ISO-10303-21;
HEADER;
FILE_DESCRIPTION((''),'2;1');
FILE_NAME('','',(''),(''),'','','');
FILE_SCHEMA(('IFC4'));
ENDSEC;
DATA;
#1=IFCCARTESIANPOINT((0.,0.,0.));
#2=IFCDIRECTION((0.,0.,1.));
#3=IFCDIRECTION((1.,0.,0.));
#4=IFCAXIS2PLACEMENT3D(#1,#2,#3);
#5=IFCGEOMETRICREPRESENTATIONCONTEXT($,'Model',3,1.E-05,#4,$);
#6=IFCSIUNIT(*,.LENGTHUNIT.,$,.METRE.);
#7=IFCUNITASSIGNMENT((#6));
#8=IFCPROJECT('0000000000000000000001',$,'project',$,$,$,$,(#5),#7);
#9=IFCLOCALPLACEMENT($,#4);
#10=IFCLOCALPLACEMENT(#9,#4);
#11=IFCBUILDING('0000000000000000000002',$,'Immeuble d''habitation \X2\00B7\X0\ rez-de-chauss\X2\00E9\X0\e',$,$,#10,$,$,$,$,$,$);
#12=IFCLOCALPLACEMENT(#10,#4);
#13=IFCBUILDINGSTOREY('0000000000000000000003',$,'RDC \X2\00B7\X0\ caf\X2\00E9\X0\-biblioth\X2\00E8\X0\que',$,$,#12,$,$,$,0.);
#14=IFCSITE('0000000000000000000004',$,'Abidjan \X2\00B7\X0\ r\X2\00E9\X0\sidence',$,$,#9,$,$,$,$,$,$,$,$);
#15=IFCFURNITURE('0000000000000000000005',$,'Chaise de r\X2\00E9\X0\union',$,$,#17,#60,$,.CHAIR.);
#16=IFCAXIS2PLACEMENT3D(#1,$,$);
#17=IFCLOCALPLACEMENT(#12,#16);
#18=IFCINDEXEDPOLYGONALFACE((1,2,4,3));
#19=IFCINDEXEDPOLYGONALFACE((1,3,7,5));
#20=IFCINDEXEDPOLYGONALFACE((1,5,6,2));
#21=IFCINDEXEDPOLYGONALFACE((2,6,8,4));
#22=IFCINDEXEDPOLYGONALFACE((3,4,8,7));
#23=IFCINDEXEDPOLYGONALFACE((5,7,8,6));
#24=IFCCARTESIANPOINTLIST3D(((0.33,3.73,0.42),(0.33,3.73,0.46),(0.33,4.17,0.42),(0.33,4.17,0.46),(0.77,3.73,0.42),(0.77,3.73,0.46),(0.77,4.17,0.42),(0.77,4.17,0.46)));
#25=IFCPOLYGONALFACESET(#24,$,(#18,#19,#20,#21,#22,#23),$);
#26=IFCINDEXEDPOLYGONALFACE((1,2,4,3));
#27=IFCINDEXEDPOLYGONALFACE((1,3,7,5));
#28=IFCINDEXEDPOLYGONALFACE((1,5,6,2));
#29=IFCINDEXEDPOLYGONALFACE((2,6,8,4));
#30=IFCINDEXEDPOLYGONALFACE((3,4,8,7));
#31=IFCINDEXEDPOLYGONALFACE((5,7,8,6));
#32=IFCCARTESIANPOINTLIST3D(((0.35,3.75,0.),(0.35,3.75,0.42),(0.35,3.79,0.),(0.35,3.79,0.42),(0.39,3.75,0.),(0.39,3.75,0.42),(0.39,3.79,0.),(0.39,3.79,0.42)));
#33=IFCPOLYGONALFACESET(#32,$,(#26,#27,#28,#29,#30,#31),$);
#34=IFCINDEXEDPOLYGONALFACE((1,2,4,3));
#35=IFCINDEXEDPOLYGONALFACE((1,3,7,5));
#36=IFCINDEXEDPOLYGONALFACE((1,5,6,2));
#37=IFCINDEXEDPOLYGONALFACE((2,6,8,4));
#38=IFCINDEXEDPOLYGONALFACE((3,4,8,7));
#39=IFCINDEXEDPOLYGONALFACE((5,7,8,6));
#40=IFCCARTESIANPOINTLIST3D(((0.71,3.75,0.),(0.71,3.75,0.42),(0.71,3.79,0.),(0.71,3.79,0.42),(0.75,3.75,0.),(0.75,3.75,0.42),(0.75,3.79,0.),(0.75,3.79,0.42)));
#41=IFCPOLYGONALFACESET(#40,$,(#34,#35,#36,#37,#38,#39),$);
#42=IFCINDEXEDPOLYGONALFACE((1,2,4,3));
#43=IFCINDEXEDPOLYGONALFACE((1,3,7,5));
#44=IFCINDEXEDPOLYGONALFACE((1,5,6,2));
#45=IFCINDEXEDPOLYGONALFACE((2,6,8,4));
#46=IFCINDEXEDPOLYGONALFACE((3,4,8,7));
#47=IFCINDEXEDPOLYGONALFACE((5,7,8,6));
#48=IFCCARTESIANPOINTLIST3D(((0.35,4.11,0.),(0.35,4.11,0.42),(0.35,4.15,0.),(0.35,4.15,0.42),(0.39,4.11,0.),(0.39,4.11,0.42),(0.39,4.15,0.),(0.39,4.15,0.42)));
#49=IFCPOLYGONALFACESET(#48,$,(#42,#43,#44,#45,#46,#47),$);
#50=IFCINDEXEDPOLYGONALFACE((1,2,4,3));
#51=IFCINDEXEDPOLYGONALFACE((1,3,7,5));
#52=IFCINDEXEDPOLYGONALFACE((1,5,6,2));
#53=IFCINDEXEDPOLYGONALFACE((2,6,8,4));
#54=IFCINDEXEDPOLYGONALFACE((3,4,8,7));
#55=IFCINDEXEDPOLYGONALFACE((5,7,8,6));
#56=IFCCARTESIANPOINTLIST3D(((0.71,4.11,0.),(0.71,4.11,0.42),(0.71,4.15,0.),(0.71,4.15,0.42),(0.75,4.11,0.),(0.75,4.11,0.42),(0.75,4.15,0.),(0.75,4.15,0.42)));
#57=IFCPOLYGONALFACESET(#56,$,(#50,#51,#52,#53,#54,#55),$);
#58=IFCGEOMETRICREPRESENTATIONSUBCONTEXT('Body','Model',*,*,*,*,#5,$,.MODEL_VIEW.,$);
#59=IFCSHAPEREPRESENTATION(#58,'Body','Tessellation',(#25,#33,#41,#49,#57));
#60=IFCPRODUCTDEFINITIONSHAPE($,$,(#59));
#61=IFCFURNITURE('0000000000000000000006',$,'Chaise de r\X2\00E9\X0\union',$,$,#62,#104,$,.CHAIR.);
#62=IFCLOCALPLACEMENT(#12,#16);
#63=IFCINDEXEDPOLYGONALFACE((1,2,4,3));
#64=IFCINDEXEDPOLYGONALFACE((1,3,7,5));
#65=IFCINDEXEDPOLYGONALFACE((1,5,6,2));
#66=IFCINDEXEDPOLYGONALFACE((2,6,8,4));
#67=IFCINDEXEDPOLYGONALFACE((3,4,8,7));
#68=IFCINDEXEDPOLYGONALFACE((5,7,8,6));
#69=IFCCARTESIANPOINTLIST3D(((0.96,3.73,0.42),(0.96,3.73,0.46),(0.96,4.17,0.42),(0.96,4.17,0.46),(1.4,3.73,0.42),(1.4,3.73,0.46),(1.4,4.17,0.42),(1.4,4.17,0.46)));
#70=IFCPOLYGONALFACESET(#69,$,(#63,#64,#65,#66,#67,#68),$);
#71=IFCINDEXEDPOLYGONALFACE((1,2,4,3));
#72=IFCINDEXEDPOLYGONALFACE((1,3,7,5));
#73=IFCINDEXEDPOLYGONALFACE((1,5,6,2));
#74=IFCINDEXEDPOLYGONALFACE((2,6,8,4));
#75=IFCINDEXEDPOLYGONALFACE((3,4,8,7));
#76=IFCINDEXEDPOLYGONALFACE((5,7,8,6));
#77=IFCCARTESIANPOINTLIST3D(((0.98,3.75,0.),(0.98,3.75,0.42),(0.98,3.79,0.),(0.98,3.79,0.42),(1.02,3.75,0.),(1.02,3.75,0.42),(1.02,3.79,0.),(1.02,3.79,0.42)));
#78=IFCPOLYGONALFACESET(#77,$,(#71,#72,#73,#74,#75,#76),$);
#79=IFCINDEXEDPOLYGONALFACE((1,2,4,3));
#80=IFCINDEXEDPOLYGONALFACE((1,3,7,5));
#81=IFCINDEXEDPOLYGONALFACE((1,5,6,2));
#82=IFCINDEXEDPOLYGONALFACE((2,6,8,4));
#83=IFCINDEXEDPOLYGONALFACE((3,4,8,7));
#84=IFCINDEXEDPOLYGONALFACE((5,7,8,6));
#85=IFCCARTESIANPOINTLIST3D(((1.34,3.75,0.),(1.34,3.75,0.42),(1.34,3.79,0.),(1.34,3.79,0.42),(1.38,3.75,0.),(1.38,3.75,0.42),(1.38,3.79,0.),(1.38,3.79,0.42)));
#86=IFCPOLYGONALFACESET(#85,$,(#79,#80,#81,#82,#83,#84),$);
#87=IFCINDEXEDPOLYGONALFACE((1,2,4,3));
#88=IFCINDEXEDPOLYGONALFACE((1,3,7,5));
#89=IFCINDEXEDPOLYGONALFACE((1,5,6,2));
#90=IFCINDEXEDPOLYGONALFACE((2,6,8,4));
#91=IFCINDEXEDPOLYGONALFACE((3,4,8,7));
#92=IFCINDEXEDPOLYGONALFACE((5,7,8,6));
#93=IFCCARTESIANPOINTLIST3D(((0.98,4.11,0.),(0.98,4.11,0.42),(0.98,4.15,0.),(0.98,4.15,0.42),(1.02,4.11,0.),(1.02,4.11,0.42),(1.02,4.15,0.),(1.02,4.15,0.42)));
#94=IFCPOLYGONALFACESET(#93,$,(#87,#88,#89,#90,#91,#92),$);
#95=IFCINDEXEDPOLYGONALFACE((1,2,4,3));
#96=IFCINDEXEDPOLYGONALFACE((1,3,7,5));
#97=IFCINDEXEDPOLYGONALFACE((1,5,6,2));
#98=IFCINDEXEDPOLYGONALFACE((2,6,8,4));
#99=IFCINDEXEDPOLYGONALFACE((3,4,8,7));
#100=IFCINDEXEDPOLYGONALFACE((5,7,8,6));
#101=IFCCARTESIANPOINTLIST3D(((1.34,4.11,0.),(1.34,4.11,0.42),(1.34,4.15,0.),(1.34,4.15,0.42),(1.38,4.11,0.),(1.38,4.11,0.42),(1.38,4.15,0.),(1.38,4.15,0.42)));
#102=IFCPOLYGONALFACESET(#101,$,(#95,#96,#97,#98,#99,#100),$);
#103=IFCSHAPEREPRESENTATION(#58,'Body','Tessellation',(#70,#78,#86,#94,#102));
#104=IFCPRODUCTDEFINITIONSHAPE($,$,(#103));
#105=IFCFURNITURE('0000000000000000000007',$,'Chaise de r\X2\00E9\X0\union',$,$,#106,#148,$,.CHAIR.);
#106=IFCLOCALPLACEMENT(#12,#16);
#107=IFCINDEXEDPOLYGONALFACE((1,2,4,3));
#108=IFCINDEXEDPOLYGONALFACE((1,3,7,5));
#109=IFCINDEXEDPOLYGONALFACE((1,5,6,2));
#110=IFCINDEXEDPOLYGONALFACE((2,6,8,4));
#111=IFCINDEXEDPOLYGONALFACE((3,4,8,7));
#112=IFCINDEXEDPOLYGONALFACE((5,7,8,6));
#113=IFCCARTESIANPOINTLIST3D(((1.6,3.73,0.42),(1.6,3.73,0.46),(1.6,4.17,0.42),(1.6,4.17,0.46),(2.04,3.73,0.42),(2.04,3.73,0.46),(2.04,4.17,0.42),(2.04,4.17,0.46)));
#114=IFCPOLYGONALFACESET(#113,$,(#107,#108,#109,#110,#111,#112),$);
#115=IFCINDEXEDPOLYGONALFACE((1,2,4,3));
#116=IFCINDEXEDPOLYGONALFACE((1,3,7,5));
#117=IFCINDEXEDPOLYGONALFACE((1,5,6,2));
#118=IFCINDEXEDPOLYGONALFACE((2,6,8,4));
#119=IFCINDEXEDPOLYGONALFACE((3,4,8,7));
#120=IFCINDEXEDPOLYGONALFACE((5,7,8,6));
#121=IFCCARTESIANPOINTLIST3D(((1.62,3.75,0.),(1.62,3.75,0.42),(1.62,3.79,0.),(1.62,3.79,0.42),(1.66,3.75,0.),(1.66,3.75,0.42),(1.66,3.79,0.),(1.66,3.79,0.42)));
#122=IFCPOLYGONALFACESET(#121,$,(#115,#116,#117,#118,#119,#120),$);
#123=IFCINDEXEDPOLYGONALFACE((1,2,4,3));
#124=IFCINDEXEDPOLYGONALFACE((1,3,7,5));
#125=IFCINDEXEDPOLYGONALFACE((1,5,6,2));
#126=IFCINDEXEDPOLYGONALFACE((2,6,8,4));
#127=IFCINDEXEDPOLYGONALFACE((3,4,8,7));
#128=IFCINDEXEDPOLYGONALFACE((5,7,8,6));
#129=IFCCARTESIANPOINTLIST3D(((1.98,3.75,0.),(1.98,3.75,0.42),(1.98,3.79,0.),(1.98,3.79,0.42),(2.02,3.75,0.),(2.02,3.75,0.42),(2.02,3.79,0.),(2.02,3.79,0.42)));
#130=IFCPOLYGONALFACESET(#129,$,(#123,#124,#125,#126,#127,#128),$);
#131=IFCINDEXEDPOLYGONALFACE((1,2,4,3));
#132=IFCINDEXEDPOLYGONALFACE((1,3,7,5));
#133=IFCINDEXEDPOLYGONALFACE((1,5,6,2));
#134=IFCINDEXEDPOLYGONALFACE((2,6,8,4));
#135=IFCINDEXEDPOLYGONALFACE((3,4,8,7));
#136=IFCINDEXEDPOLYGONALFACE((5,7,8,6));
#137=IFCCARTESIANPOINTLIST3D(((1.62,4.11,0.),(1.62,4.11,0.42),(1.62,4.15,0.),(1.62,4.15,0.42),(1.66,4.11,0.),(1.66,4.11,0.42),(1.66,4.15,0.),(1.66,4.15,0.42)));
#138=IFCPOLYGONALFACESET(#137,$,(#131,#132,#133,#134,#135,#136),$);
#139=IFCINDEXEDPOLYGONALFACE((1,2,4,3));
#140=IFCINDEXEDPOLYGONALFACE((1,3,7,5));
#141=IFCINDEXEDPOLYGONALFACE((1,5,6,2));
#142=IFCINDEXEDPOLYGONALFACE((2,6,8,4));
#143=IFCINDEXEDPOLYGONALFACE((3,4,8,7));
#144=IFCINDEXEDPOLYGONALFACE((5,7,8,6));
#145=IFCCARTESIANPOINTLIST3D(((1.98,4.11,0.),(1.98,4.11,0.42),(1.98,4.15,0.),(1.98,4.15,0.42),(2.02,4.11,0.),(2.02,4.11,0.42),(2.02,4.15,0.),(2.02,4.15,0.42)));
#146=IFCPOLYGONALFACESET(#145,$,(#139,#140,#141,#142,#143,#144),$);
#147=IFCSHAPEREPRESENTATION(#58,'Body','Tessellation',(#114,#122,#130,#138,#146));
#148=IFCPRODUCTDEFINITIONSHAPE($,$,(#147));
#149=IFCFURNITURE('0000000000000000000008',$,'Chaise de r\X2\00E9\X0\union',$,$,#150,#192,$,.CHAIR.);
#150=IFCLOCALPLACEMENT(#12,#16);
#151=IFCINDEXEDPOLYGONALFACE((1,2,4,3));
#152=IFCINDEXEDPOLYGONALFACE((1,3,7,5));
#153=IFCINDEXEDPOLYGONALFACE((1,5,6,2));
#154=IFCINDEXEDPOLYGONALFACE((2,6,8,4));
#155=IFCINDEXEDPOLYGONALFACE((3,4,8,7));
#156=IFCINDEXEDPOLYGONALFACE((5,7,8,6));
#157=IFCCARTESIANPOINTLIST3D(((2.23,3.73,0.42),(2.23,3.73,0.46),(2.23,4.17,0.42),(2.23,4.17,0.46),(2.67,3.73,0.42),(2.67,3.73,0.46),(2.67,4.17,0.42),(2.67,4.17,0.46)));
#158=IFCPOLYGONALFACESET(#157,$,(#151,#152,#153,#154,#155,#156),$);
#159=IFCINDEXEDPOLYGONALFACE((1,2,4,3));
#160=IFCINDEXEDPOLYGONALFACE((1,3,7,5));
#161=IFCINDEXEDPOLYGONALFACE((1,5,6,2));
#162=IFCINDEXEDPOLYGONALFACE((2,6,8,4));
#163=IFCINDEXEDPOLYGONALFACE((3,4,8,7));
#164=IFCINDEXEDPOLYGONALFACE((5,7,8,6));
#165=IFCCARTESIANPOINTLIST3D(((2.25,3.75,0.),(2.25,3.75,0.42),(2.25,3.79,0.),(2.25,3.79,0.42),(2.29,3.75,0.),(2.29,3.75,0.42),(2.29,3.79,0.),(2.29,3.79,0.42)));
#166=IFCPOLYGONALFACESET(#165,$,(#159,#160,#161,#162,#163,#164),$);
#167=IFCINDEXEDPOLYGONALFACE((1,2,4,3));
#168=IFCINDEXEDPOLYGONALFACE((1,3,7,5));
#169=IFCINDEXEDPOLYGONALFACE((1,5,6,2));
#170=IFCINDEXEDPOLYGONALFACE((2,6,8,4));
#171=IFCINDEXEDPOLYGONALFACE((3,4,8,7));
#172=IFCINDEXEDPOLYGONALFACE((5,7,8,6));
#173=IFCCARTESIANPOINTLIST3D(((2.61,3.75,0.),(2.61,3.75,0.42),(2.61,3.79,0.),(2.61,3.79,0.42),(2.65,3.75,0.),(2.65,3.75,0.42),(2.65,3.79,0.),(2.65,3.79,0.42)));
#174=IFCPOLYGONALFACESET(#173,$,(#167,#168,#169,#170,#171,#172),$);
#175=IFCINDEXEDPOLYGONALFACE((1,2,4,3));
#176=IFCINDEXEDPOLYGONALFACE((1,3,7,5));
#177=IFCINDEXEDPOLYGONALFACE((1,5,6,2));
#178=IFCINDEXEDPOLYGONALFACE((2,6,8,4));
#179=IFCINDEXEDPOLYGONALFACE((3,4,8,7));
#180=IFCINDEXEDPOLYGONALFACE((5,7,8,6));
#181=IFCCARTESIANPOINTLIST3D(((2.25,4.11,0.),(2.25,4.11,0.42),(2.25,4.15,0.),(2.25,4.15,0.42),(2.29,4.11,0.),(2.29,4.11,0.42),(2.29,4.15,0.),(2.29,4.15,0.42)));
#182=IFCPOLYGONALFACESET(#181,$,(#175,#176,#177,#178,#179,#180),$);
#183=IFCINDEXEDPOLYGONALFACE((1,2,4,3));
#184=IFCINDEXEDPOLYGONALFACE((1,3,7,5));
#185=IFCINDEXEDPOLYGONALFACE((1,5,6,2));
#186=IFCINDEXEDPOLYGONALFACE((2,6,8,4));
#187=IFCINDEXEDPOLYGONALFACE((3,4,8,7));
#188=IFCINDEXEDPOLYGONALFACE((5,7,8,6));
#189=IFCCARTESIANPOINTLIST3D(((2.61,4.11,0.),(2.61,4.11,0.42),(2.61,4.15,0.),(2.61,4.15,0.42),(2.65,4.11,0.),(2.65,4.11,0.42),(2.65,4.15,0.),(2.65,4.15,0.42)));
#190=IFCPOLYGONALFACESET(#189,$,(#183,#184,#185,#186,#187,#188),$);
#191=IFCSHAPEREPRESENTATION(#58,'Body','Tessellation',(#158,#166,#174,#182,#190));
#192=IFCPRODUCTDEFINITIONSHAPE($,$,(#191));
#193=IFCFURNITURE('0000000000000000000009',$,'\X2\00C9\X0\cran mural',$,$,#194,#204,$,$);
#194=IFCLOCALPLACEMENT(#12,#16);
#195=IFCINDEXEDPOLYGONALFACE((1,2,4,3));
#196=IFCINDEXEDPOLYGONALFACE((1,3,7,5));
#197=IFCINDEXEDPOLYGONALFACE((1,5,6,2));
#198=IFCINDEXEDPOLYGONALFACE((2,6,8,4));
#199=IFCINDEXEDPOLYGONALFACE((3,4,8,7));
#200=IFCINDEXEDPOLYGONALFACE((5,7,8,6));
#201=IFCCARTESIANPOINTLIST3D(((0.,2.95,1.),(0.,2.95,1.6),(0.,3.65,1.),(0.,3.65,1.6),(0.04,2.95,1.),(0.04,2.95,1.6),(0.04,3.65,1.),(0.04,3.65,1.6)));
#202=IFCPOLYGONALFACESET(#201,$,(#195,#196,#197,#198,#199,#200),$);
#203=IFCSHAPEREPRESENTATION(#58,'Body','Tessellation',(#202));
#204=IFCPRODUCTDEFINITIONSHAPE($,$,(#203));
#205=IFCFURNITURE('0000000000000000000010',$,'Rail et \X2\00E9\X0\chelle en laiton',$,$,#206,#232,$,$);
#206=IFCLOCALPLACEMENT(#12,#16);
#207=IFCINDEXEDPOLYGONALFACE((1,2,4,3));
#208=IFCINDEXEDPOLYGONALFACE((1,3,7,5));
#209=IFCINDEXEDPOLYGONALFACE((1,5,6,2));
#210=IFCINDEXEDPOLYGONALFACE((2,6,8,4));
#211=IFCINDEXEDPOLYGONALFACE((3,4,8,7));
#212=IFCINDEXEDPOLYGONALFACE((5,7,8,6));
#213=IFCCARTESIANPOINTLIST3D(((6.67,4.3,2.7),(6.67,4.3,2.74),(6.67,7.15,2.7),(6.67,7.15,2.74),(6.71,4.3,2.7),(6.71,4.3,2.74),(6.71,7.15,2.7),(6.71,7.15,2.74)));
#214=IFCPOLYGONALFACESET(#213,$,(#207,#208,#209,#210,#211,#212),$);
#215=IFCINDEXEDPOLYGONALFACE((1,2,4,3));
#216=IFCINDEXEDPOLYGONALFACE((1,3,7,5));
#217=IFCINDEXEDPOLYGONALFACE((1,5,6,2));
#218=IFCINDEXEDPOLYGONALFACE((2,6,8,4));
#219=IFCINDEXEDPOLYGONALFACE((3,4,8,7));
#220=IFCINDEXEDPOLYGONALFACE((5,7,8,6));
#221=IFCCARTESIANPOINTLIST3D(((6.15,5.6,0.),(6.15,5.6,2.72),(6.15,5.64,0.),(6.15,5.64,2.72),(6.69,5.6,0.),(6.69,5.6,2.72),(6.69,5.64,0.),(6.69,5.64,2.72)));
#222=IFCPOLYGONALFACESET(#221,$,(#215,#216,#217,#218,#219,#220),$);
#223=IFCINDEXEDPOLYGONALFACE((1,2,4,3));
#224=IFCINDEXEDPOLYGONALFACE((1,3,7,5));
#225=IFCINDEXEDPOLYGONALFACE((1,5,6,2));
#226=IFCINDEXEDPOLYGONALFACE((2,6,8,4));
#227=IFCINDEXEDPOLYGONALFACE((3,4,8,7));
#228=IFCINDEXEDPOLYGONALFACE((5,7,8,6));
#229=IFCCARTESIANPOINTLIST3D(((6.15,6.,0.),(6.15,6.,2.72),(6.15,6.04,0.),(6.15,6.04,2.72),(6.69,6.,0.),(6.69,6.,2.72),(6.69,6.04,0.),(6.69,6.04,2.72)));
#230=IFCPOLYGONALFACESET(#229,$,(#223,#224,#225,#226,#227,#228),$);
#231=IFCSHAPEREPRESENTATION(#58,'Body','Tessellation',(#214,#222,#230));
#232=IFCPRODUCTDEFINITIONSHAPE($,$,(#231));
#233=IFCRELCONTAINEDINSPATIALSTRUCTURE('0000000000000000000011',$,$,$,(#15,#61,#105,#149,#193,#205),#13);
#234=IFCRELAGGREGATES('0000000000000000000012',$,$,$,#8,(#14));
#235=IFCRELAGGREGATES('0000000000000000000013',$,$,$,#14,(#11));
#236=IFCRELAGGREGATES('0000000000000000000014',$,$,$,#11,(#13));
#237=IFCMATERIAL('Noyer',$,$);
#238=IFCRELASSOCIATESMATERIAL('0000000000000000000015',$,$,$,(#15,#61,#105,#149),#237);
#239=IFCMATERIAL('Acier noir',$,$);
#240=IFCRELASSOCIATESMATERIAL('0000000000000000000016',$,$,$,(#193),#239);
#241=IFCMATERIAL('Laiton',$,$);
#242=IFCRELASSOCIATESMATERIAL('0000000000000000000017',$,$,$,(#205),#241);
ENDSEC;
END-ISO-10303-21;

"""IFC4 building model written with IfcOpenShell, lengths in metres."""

from ifc_helpers import new_model, si_unit, frame, frame_2d, origin, origin_with_axes, place, context, subcontext, project, spatial, rectangle, extrude, material, element, save


model = new_model("IFC4")

# Units and contexts
model_context = context("Model", 3, precision=1e-05, world=origin_with_axes())
body_context = subcontext(model_context, "Body", "Model", "MODEL_VIEW")
ifc_project = project(units=[si_unit("LENGTHUNIT", "METRE")], contexts=[model_context])

# Site, building, storey
site_placement = place(None, origin_with_axes())
site = spatial("IfcSite", under=ifc_project, at=site_placement, Name="Abidjan · résidence")
building_placement = place(site_placement, origin_with_axes())
building = spatial("IfcBuilding", under=site, at=building_placement, Name="Immeuble d'habitation · rez-de-chaussée")
storey_placement = place(building_placement, origin_with_axes())
storey = spatial("IfcBuildingStorey", under=building, at=storey_placement, Name="RDC · café-bibliothèque", Elevation=0.0)

# Furniture
ifc_material_1 = material(Name="Noyer")
furniture_1_placement = place(storey_placement, origin_with_axes())
element("IfcFurniture", 1, at=furniture_1_placement, inside=storey, material=ifc_material_1, Name="Chaise de réunion", PredefinedType="CHAIR", context=body_context, shape_type="SweptSolid", body=[
    extrude(rectangle(XDim=0.44, YDim=0.44, at=frame_2d((0.55, 3.95))), frame((0.0, 0.0, 0.42)), (0.0, 0.0, 1.0), 0.04),
    extrude(rectangle(XDim=0.04, YDim=0.04, at=frame_2d((0.37, 3.77))), origin(), (0.0, 0.0, 1.0), 0.42),
    extrude(rectangle(XDim=0.04, YDim=0.04, at=frame_2d((0.73, 3.77))), origin(), (0.0, 0.0, 1.0), 0.42),
    extrude(rectangle(XDim=0.04, YDim=0.04, at=frame_2d((0.37, 4.13))), origin(), (0.0, 0.0, 1.0), 0.42),
    extrude(rectangle(XDim=0.04, YDim=0.04, at=frame_2d((0.73, 4.13))), origin(), (0.0, 0.0, 1.0), 0.42),
])
furniture_2_placement = place(storey_placement, origin_with_axes())
element("IfcFurniture", 2, at=furniture_2_placement, inside=storey, material=ifc_material_1, Name="Chaise de réunion", PredefinedType="CHAIR", context=body_context, shape_type="SweptSolid", body=[
    extrude(rectangle(XDim=0.44, YDim=0.44, at=frame_2d((1.18, 3.95))), frame((0.0, 0.0, 0.42)), (0.0, 0.0, 1.0), 0.04),
    extrude(rectangle(XDim=0.04, YDim=0.04, at=frame_2d((1.0, 3.77))), origin(), (0.0, 0.0, 1.0), 0.42),
    extrude(rectangle(XDim=0.04, YDim=0.04, at=frame_2d((1.36, 3.77))), origin(), (0.0, 0.0, 1.0), 0.42),
    extrude(rectangle(XDim=0.04, YDim=0.04, at=frame_2d((1.0, 4.13))), origin(), (0.0, 0.0, 1.0), 0.42),
    extrude(rectangle(XDim=0.04, YDim=0.04, at=frame_2d((1.36, 4.13))), origin(), (0.0, 0.0, 1.0), 0.42),
])
furniture_3_placement = place(storey_placement, origin_with_axes())
element("IfcFurniture", 3, at=furniture_3_placement, inside=storey, material=ifc_material_1, Name="Chaise de réunion", PredefinedType="CHAIR", context=body_context, shape_type="SweptSolid", body=[
    extrude(rectangle(XDim=0.44, YDim=0.44, at=frame_2d((1.82, 3.95))), frame((0.0, 0.0, 0.42)), (0.0, 0.0, 1.0), 0.04),
    extrude(rectangle(XDim=0.04, YDim=0.04, at=frame_2d((1.64, 3.77))), origin(), (0.0, 0.0, 1.0), 0.42),
    extrude(rectangle(XDim=0.04, YDim=0.04, at=frame_2d((2.0, 3.77))), origin(), (0.0, 0.0, 1.0), 0.42),
    extrude(rectangle(XDim=0.04, YDim=0.04, at=frame_2d((1.64, 4.13))), origin(), (0.0, 0.0, 1.0), 0.42),
    extrude(rectangle(XDim=0.04, YDim=0.04, at=frame_2d((2.0, 4.13))), origin(), (0.0, 0.0, 1.0), 0.42),
])
furniture_4_placement = place(storey_placement, origin_with_axes())
element("IfcFurniture", 4, at=furniture_4_placement, inside=storey, material=ifc_material_1, Name="Chaise de réunion", PredefinedType="CHAIR", context=body_context, shape_type="SweptSolid", body=[
    extrude(rectangle(XDim=0.44, YDim=0.44, at=frame_2d((2.45, 3.95))), frame((0.0, 0.0, 0.42)), (0.0, 0.0, 1.0), 0.04),
    extrude(rectangle(XDim=0.04, YDim=0.04, at=frame_2d((2.27, 3.77))), origin(), (0.0, 0.0, 1.0), 0.42),
    extrude(rectangle(XDim=0.04, YDim=0.04, at=frame_2d((2.63, 3.77))), origin(), (0.0, 0.0, 1.0), 0.42),
    extrude(rectangle(XDim=0.04, YDim=0.04, at=frame_2d((2.27, 4.13))), origin(), (0.0, 0.0, 1.0), 0.42),
    extrude(rectangle(XDim=0.04, YDim=0.04, at=frame_2d((2.63, 4.13))), origin(), (0.0, 0.0, 1.0), 0.42),
])
ifc_material_2 = material(Name="Acier noir")
furniture_5_placement = place(storey_placement, origin_with_axes())
element("IfcFurniture", 5, at=furniture_5_placement, inside=storey, material=ifc_material_2, Name="Écran mural", context=body_context, shape_type="SweptSolid", body=[
    extrude(rectangle(XDim=0.04, YDim=0.7, at=frame_2d((0.02, 3.3))), frame((0.0, 0.0, 1.0)), (0.0, 0.0, 1.0), 0.6),
])
ifc_material_3 = material(Name="Laiton")
furniture_6_placement = place(storey_placement, origin_with_axes())
element("IfcFurniture", 6, at=furniture_6_placement, inside=storey, material=ifc_material_3, Name="Rail et échelle en laiton", context=body_context, shape_type="SweptSolid", body=[
    extrude(rectangle(XDim=0.04, YDim=2.85, at=frame_2d((6.69, 5.725))), frame((0.0, 0.0, 2.7)), (0.0, 0.0, 1.0), 0.04),
    extrude(rectangle(XDim=0.54, YDim=0.04, at=frame_2d((6.42, 5.62))), origin(), (0.0, 0.0, 1.0), 2.72),
    extrude(rectangle(XDim=0.54, YDim=0.04, at=frame_2d((6.42, 6.02))), origin(), (0.0, 0.0, 1.0), 2.72),
])

save(model, "model.ifc")
